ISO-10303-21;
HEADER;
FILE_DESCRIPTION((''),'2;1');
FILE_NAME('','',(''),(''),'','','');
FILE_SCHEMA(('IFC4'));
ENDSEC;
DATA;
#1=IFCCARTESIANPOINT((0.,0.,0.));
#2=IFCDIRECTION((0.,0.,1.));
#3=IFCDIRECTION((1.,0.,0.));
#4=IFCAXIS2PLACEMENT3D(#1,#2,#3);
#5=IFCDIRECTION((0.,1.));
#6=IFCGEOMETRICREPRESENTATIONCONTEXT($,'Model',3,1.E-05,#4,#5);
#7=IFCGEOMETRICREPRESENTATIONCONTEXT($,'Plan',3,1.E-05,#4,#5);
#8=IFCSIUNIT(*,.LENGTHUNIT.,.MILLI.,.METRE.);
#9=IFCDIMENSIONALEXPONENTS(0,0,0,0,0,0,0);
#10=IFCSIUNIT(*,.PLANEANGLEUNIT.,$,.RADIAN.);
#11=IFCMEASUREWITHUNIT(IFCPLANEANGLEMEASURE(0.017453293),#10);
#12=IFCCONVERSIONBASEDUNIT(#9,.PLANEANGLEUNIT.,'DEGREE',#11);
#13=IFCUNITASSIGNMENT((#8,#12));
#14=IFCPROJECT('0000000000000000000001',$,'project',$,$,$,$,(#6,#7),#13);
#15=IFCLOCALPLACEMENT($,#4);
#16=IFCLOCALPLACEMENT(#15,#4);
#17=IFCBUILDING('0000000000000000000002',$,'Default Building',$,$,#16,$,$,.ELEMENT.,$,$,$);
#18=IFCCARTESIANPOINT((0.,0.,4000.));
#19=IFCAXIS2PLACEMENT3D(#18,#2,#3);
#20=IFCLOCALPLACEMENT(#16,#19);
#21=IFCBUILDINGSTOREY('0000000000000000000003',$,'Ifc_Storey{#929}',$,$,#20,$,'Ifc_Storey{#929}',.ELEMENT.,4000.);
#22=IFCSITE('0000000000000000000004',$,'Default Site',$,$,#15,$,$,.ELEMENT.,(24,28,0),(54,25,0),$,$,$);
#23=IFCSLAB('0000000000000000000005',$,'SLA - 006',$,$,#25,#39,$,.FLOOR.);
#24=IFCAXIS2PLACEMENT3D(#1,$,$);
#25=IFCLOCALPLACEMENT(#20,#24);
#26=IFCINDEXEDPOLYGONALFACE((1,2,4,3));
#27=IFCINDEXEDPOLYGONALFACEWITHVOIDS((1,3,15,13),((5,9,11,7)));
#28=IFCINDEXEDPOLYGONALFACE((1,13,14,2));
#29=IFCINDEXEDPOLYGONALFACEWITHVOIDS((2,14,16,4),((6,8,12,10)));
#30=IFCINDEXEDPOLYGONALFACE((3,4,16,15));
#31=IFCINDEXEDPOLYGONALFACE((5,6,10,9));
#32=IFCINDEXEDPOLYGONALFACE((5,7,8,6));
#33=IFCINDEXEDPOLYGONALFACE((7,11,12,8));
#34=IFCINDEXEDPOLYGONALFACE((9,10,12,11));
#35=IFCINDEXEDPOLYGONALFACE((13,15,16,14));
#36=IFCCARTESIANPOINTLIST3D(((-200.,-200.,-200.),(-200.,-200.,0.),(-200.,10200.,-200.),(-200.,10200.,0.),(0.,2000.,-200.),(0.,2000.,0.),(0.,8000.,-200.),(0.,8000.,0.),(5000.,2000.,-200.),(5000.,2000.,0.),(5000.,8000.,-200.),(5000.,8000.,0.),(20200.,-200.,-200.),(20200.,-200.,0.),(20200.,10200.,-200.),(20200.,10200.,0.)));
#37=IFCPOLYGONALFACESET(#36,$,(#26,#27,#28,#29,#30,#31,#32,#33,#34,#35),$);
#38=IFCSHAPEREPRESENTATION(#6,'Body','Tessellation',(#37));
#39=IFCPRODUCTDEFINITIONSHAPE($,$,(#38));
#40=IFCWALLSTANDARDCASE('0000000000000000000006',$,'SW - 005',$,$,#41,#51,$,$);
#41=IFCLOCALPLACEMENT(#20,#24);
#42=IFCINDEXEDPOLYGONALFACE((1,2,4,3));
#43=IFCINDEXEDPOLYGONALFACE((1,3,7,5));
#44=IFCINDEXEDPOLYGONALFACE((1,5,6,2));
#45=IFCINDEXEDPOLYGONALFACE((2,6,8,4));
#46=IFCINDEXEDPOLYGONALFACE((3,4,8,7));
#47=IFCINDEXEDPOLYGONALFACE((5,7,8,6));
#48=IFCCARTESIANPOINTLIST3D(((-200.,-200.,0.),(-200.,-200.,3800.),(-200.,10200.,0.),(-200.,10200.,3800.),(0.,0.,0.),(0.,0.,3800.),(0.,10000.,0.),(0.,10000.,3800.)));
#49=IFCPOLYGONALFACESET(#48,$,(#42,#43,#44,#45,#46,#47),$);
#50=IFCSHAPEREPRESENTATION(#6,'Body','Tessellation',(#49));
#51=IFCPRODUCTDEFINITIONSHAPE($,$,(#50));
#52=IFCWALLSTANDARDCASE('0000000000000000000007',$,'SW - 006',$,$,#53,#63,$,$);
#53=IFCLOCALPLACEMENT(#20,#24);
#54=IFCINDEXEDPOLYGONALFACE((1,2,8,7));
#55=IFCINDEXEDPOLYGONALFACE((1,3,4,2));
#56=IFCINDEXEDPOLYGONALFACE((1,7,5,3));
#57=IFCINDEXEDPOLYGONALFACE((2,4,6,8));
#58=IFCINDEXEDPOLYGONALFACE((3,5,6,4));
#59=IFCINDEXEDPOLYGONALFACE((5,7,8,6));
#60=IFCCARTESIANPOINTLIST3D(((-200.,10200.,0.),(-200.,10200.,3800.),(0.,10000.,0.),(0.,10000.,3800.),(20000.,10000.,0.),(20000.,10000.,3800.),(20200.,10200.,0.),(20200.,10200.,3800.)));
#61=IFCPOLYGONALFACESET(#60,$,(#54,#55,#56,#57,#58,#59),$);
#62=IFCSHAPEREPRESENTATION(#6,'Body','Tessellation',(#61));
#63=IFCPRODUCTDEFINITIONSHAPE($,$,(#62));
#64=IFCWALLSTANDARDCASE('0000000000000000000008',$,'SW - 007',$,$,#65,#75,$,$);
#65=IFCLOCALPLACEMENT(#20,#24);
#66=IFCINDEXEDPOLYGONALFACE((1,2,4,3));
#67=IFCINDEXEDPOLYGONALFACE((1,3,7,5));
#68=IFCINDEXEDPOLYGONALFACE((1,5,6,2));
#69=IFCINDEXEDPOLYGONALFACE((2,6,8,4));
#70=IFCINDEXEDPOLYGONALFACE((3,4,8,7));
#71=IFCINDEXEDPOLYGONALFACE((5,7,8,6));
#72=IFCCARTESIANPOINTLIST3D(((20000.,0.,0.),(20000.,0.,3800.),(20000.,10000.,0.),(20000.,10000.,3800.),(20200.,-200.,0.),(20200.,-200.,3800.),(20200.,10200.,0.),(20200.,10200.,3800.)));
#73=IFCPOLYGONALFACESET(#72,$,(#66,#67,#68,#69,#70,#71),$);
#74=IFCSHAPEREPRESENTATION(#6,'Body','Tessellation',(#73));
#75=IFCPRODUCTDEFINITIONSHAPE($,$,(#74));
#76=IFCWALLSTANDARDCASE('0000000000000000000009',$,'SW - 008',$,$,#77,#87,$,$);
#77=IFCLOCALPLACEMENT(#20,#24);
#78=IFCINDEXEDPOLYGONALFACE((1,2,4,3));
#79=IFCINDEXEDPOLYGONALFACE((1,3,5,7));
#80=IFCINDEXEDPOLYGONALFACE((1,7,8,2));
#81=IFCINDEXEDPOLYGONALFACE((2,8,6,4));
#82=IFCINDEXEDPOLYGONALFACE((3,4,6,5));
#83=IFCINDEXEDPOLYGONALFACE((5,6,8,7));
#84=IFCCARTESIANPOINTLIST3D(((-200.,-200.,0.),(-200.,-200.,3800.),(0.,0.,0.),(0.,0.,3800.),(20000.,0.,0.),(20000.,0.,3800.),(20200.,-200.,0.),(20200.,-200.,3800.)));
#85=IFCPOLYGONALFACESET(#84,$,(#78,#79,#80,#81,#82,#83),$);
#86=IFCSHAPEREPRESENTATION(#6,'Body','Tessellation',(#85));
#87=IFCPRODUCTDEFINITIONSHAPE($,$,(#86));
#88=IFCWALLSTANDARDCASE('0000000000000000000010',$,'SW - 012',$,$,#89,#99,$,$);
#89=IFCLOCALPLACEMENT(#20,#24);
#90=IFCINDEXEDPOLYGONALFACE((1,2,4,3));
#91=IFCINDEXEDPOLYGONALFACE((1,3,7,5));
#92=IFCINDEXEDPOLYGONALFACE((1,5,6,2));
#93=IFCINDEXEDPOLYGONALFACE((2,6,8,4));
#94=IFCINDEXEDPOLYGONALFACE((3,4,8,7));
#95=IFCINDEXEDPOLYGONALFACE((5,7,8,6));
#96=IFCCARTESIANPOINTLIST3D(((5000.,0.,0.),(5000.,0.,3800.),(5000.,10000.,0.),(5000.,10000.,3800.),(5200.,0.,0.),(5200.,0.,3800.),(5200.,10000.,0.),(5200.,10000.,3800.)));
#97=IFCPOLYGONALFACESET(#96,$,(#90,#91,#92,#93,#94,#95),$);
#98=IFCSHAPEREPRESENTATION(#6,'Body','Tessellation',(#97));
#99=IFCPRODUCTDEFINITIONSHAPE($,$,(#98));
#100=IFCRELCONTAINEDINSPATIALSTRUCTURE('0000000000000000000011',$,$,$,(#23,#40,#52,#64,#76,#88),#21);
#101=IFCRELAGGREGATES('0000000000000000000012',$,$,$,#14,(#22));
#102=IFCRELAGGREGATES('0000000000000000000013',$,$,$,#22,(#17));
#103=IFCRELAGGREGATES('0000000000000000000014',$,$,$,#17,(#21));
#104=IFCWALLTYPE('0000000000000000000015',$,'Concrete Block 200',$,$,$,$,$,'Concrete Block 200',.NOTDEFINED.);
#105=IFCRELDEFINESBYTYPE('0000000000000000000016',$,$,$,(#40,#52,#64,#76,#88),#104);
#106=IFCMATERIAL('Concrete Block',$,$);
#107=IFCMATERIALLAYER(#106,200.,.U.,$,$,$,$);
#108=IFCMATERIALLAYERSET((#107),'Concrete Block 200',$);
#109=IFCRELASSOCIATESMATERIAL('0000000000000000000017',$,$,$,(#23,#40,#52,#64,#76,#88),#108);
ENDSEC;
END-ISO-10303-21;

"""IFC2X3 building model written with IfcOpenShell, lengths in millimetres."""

from ifc_helpers import new_model, entity, si_unit, converted_unit, direction, frame, origin_with_axes, place, context, project, spatial, polyline, outline, extrude, material, layer, layer_set, layer_usage, type_object, element, save


model = new_model("IFC2X3")

# Units and contexts
model_context = context("Model", 3, precision=1e-05, world=origin_with_axes(), true_north=direction((0.0, 1.0)))
plan_context = context("Plan", 3, precision=1e-05, world=origin_with_axes(), true_north=direction((0.0, 1.0)))
ifc_project = project(units=[si_unit("LENGTHUNIT", "METRE", prefix="MILLI"), converted_unit("PLANEANGLEUNIT", "DEGREE", entity("IfcPlaneAngleMeasure", 0.017453293), si_unit("PLANEANGLEUNIT", "RADIAN"), dimensions=[0, 0, 0, 0, 0, 0, 0])], contexts=[model_context, plan_context])

# Site, building, storey
site_placement = place(None, origin_with_axes())
site = spatial("IfcSite", under=ifc_project, at=site_placement, Name="Default Site", CompositionType="ELEMENT", RefLatitude=(24, 28, 0), RefLongitude=(54, 25, 0))
building_placement = place(site_placement, origin_with_axes())
building = spatial("IfcBuilding", under=site, at=building_placement, Name="Default Building", CompositionType="ELEMENT")
storey_placement = place(building_placement, frame((0.0, 0.0, 4000.0), z_axis=(0.0, 0.0, 1.0), x_axis=(1.0, 0.0, 0.0)))
storey = spatial("IfcBuildingStorey", under=building, at=storey_placement, Name="Ifc_Storey{#929}", LongName="Ifc_Storey{#929}", CompositionType="ELEMENT", Elevation=4000.0)

# Slab, opening
ifc_material = material(Name="Concrete Block")
ifc_layer = layer(ifc_material, 200.0, ventilated="UNKNOWN")
ifc_layer_set = layer_set([ifc_layer], Name="Concrete Block 200")
ifc_layer_usage_1 = layer_usage(ifc_layer_set, "AXIS3", "NEGATIVE", 200.0)
slab_placement = place(storey_placement, frame((-200.0, -200.0, -200.0), z_axis=(0.0, 0.0, 1.0), x_axis=(1.0, 0.0, 0.0)))
slab = element("IfcSlab", 1, at=slab_placement, inside=storey, material=ifc_layer_usage_1, Name="SLA - 006", PredefinedType="FLOOR", context=model_context, shape_type="SweptSolid", body=[
    extrude(outline(polyline([(0.0, 0.0), (20400.0, 0.0), (20400.0, 10400.0), (0.0, 10400.0), (0.0, 0.0)])), origin_with_axes(), (0.0, 0.0, 1.0), 200.0),
])
opening_placement = place(slab_placement, origin_with_axes())
element("IfcOpeningElement", 2, at=opening_placement, cuts=slab, context=model_context, shape_type="SweptSolid", body=[
    extrude(outline(polyline([(5200.0, 2200.0), (200.0, 2200.0), (200.0, 8200.0), (5200.0, 8200.0), (5200.0, 2200.0)])), origin_with_axes(), (0.0, 0.0, 1.0), 200.0),
])

# Walls
ifc_layer_usage_2 = layer_usage(ifc_layer_set, "AXIS2", "POSITIVE", 0.0)
wall_type = type_object("IfcWallType", Name="Concrete Block 200", ElementType="Concrete Block 200", PredefinedType="NOTDEFINED")
wall_1_placement = place(storey_placement, frame((0.0, 0.0, 0.0), z_axis=(0.0, 0.0, 1.0), x_axis=(0.0, 1.0, 0.0)))
element("IfcWallStandardCase", 3, at=wall_1_placement, inside=storey, type_object=wall_type, material=ifc_layer_usage_2, Name="SW - 005", context=model_context, shape_type="SweptSolid", body=[
    extrude(outline(polyline([(0.0, 0.0), (10000.0, 0.0), (10200.0, 200.0), (-200.0, 200.0), (0.0, 0.0)])), origin_with_axes(), (0.0, 0.0, 1.0), 3800.0),
])
ifc_layer_usage_3 = layer_usage(ifc_layer_set, "AXIS2", "POSITIVE", 0.0)
wall_2_placement = place(storey_placement, frame((0.0, 10000.0, 0.0), z_axis=(0.0, 0.0, 1.0), x_axis=(1.0, 0.0, 0.0)))
element("IfcWallStandardCase", 4, at=wall_2_placement, inside=storey, type_object=wall_type, material=ifc_layer_usage_3, Name="SW - 006", context=model_context, shape_type="SweptSolid", body=[
    extrude(outline(polyline([(0.0, 0.0), (20000.0, 0.0), (20200.0, 200.0), (-200.0, 200.0), (0.0, 0.0)])), origin_with_axes(), (0.0, 0.0, 1.0), 3800.0),
])
ifc_layer_usage_4 = layer_usage(ifc_layer_set, "AXIS2", "POSITIVE", 0.0)
wall_3_placement = place(storey_placement, frame((20000.0, 10000.0, 0.0), z_axis=(0.0, 0.0, 1.0), x_axis=(0.0, -1.0, 0.0)))
element("IfcWallStandardCase", 5, at=wall_3_placement, inside=storey, type_object=wall_type, material=ifc_layer_usage_4, Name="SW - 007", context=model_context, shape_type="SweptSolid", body=[
    extrude(outline(polyline([(0.0, 0.0), (10000.0, 0.0), (10200.0, 200.0), (-200.0, 200.0), (0.0, 0.0)])), origin_with_axes(), (0.0, 0.0, 1.0), 3800.0),
])
ifc_layer_usage_5 = layer_usage(ifc_layer_set, "AXIS2", "POSITIVE", 0.0)
wall_4_placement = place(storey_placement, frame((20000.0, 0.0, 0.0), z_axis=(0.0, 0.0, 1.0), x_axis=(-1.0, 0.0, 0.0)))
element("IfcWallStandardCase", 6, at=wall_4_placement, inside=storey, type_object=wall_type, material=ifc_layer_usage_5, Name="SW - 008", context=model_context, shape_type="SweptSolid", body=[
    extrude(outline(polyline([(0.0, 0.0), (20000.0, 0.0), (20200.0, 200.0), (-200.0, 200.0), (0.0, 0.0)])), origin_with_axes(), (0.0, 0.0, 1.0), 3800.0),
])
ifc_layer_usage_6 = layer_usage(ifc_layer_set, "AXIS2", "POSITIVE", 0.0)
wall_5_placement = place(storey_placement, frame((5000.0, 10000.0, 0.0), z_axis=(0.0, 0.0, 1.0), x_axis=(0.0, -1.0, 0.0)))
element("IfcWallStandardCase", 7, at=wall_5_placement, inside=storey, type_object=wall_type, material=ifc_layer_usage_6, Name="SW - 012", context=model_context, shape_type="SweptSolid", body=[
    extrude(outline(polyline([(0.0, 0.0), (10000.0, 0.0), (10000.0, 200.0), (0.0, 200.0), (0.0, 0.0)])), origin_with_axes(), (0.0, 0.0, 1.0), 3800.0),
])

save(model, "model.ifc")
